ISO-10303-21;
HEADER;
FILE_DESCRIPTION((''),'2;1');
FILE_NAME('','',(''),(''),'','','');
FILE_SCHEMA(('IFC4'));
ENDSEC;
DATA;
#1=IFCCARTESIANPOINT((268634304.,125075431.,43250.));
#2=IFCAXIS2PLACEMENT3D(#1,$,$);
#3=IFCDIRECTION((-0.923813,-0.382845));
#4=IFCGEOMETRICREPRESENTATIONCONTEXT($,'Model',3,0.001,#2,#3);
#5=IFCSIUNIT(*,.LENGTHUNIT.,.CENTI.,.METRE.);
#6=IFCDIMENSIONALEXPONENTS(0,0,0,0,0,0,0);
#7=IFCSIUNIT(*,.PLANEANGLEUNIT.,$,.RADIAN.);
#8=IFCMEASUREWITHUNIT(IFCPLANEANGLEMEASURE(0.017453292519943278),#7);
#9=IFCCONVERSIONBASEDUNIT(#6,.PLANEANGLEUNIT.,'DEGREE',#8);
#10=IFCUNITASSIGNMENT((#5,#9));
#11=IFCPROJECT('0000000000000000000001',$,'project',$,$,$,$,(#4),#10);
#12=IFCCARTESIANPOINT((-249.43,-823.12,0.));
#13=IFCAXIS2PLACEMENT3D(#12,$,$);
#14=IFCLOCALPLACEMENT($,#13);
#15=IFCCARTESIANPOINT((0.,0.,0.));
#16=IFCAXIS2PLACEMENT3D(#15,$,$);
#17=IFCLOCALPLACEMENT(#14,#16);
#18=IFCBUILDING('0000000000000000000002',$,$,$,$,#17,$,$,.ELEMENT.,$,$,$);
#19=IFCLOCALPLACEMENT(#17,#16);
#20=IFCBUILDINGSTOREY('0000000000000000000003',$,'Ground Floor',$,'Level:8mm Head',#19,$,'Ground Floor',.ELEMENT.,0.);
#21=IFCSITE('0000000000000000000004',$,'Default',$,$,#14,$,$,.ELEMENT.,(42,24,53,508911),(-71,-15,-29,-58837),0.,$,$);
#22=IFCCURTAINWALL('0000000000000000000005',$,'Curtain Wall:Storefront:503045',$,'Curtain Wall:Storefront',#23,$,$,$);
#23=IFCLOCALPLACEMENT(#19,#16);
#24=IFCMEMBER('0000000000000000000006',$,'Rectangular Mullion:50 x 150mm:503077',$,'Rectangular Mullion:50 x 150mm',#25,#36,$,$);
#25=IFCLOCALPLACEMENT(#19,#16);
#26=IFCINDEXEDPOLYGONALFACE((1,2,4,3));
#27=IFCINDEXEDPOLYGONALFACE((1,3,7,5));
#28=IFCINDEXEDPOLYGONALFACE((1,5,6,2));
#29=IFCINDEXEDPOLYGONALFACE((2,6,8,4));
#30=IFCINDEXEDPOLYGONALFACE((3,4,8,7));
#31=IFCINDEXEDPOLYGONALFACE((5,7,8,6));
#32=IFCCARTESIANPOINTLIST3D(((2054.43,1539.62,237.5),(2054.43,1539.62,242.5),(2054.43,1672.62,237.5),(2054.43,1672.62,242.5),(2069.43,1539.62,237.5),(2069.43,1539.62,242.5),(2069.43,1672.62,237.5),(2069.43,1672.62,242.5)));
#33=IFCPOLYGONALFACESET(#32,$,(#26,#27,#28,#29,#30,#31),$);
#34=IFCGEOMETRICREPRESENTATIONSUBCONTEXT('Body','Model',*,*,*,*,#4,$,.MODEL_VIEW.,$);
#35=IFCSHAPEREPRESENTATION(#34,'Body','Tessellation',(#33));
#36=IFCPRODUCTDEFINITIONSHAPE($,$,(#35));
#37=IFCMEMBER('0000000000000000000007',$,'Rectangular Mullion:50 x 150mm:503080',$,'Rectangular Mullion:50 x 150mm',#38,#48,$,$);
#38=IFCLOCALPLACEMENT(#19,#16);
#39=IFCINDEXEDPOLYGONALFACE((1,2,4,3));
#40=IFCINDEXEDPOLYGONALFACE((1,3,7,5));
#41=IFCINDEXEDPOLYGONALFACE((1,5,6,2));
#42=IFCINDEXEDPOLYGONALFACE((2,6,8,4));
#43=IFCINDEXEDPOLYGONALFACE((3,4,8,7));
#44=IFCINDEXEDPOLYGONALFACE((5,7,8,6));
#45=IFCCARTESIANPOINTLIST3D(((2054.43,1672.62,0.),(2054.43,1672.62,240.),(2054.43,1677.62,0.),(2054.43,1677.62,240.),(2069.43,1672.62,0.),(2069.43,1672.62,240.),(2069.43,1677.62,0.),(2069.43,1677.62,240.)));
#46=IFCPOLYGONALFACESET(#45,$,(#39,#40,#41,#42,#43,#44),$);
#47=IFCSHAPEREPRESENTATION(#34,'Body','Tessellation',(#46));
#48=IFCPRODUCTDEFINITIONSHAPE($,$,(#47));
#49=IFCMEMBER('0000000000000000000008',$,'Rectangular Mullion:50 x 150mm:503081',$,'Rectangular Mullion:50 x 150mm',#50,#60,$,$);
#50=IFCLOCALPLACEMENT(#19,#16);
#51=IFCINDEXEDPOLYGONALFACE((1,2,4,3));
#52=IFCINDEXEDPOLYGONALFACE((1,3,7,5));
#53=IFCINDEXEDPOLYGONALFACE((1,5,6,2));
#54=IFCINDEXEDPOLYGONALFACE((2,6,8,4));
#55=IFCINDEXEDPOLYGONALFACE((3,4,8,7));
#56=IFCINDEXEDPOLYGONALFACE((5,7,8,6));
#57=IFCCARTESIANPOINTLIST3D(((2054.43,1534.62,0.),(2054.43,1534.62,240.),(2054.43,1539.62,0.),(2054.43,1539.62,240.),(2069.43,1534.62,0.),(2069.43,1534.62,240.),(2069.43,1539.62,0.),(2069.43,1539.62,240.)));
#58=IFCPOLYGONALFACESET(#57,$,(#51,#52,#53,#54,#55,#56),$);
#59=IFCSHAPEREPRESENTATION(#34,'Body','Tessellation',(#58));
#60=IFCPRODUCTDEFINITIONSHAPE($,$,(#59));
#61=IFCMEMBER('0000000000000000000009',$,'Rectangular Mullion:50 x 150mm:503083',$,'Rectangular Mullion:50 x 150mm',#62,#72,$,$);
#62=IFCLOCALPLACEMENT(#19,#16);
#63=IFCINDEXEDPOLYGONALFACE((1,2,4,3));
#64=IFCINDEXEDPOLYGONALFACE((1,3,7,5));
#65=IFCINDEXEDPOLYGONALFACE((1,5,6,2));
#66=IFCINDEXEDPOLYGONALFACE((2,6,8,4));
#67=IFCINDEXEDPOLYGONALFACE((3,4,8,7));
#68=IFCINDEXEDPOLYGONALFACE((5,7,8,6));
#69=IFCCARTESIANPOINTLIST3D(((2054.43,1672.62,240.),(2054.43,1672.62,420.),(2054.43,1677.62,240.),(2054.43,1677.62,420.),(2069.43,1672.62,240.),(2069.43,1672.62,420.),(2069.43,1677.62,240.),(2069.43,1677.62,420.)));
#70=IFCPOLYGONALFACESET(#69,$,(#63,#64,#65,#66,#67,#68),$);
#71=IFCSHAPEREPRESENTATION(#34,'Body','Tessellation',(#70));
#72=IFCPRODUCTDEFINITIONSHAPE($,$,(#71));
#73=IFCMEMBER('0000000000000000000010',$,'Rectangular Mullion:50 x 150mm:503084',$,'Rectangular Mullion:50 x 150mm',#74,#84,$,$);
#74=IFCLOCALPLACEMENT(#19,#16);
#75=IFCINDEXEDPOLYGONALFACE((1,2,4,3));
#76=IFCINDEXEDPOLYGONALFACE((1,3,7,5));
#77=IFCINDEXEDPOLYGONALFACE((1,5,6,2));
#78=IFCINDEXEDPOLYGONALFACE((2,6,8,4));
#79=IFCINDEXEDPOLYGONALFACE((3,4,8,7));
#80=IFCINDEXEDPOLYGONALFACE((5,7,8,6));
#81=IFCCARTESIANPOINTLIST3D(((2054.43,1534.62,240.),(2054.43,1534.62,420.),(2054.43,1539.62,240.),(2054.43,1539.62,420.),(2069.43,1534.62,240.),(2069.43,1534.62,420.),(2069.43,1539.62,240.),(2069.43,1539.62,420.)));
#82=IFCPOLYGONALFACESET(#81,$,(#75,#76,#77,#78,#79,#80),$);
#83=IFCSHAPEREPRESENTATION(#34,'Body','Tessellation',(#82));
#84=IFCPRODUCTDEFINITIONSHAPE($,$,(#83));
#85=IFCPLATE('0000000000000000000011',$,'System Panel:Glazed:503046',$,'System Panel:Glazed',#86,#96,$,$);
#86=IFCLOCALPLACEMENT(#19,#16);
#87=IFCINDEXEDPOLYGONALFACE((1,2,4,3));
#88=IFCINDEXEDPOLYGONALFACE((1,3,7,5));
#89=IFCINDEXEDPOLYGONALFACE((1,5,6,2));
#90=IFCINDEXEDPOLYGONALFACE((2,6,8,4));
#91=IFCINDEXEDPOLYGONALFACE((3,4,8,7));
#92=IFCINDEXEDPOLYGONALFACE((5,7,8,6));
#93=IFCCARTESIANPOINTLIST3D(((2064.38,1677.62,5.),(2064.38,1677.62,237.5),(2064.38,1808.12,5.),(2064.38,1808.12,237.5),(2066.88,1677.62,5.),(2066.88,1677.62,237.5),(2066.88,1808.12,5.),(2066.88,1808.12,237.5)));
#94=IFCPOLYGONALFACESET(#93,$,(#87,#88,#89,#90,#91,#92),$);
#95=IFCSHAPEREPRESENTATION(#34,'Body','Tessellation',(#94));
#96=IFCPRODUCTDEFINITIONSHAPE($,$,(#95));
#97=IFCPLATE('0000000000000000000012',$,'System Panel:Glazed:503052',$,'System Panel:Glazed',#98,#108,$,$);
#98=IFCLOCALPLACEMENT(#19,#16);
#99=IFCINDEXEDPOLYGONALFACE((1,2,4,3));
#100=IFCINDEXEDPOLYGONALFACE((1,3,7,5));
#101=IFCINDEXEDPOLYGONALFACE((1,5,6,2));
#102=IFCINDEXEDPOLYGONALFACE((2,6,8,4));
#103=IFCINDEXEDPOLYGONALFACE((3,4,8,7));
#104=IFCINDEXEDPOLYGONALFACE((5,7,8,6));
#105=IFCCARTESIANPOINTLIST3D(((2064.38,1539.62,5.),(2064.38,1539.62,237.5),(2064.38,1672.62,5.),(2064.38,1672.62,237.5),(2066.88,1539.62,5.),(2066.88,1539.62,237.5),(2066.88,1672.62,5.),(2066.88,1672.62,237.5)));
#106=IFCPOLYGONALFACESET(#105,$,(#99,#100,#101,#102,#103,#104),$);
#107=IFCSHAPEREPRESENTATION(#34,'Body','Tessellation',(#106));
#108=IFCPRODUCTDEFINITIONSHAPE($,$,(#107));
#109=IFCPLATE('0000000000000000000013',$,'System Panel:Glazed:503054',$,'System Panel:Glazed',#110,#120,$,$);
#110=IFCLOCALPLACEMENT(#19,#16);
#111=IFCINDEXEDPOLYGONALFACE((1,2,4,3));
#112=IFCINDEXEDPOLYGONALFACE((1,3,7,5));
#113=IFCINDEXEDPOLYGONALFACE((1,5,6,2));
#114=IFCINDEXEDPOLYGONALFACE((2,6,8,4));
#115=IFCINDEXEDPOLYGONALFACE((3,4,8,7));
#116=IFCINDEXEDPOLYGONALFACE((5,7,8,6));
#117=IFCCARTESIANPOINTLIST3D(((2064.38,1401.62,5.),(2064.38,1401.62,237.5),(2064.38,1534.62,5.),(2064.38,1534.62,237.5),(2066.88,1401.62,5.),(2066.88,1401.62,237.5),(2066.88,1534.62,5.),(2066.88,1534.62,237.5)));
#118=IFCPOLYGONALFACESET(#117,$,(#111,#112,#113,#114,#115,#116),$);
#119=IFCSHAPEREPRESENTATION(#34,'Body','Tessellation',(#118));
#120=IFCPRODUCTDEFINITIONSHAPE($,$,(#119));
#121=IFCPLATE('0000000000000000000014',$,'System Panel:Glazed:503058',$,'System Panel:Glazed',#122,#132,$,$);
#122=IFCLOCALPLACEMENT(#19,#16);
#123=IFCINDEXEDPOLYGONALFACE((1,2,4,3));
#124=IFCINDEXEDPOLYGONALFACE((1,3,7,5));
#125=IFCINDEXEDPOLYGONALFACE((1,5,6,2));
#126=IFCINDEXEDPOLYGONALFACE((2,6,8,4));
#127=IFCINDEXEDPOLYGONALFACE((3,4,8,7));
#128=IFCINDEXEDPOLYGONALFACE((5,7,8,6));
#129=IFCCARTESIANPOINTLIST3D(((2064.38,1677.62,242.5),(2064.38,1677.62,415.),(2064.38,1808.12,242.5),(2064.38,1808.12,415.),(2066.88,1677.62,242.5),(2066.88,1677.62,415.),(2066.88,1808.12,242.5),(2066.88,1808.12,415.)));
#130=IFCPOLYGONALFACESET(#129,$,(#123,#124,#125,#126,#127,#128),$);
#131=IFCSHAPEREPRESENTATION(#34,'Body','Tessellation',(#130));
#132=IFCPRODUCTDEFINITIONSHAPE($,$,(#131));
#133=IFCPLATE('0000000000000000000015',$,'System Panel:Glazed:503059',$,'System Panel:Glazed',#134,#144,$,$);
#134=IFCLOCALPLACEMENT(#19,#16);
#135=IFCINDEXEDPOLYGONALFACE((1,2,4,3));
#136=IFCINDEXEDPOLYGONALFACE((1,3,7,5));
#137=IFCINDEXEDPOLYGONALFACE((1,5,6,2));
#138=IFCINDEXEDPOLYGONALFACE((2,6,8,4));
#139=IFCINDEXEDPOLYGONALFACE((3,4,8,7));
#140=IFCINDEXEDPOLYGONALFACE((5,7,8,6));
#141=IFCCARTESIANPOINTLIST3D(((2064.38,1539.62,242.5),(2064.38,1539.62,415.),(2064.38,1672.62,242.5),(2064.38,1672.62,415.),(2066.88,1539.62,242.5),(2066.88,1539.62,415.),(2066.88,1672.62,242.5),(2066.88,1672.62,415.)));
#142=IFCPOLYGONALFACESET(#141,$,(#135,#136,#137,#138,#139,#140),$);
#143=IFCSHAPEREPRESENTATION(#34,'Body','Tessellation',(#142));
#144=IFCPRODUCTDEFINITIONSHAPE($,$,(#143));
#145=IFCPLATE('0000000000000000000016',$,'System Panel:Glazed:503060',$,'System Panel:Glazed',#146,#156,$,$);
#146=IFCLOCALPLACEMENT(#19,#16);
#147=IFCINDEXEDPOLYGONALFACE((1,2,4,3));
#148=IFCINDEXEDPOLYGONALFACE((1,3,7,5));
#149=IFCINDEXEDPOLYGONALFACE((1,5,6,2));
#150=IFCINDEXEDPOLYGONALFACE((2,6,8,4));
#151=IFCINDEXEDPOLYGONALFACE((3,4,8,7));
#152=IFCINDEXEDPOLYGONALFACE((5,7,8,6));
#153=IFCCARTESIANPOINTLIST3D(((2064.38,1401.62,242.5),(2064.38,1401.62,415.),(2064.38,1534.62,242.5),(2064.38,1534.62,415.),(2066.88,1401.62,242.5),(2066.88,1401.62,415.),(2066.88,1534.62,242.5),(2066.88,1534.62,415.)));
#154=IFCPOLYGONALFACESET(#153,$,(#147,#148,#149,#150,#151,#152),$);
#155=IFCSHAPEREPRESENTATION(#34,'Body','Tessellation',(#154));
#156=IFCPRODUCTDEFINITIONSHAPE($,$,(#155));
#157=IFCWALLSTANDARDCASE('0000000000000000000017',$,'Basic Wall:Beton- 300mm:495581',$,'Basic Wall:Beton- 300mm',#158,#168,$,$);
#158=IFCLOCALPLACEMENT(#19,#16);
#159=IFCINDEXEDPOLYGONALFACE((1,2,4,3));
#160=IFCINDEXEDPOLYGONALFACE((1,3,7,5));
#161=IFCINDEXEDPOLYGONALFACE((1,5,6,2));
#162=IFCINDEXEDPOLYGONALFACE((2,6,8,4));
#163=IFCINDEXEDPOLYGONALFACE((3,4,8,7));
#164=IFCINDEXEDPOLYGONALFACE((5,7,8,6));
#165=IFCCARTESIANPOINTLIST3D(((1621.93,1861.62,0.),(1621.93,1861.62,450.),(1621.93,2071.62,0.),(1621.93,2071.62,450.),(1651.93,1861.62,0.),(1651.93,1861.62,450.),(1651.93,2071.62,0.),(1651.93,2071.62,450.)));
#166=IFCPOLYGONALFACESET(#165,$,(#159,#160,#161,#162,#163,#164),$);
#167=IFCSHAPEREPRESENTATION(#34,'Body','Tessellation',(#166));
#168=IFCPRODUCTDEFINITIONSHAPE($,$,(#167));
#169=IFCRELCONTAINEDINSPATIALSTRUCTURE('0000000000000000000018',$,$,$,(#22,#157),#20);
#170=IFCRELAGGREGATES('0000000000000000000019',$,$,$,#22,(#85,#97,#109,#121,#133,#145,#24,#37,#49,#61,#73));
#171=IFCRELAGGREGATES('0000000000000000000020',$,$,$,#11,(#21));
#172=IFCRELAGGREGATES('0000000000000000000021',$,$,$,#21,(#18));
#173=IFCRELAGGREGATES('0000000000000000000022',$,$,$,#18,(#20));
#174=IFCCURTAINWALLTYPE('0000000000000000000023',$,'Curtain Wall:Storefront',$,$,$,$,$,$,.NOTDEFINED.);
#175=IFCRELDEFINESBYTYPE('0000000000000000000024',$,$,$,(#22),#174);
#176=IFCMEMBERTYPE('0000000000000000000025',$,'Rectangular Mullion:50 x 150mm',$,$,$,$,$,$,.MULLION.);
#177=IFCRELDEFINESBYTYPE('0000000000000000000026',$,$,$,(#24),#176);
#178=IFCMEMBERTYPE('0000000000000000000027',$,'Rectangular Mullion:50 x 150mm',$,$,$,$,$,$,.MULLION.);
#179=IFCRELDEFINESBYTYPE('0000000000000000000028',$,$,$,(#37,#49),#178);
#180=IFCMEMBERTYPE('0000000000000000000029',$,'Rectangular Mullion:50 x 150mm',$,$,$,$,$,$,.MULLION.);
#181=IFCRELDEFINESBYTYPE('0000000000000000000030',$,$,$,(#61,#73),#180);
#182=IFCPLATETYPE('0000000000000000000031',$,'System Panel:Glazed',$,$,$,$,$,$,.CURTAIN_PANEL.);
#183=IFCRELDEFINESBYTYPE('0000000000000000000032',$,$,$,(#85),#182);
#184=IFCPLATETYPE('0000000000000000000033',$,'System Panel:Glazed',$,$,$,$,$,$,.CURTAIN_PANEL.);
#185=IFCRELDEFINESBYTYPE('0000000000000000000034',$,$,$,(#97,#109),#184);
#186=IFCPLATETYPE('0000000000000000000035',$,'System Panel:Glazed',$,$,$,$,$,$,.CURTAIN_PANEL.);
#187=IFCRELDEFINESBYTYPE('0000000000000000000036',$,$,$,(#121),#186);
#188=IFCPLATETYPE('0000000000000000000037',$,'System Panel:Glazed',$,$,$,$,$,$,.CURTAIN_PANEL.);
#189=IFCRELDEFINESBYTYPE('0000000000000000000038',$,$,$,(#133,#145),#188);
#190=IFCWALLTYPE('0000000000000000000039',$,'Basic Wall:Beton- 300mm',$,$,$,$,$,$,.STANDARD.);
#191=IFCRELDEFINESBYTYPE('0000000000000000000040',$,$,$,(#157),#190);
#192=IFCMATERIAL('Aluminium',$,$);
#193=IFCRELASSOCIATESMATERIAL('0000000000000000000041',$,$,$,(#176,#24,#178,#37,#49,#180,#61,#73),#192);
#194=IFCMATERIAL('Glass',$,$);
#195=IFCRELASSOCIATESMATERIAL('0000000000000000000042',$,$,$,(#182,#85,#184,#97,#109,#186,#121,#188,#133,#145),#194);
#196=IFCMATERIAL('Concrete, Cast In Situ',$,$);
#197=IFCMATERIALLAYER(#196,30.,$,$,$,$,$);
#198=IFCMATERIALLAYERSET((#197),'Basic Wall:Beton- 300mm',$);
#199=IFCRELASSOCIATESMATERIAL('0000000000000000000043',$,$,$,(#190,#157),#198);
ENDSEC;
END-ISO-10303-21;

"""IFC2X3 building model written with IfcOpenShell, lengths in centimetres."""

from ifc_helpers import new_model, entity, si_unit, converted_unit, direction, frame, frame_2d, origin, origin_2d_with_axis, place, context, subcontext, project, spatial, rectangle, extrude, source, transform, mapped, material, layer, layer_set, layer_usage, type_object, type_shapes, element, aggregate, save


model = new_model("IFC2X3")

# Units and contexts
model_context = context("Model", 3, precision=0.001, world=frame((268634304.0, 125075431.0, 43250.0)), true_north=direction((-0.923813, -0.382845)))
body_context = subcontext(model_context, "Body", "Model", "MODEL_VIEW")
ifc_project = project(units=[si_unit("LENGTHUNIT", "METRE", prefix="CENTI"), converted_unit("PLANEANGLEUNIT", "DEGREE", entity("IfcPlaneAngleMeasure", 0.017453292519943278), si_unit("PLANEANGLEUNIT", "RADIAN"), dimensions=[0, 0, 0, 0, 0, 0, 0])], contexts=[model_context])

# Site, building, storey
site_placement = place(None, frame((-249.43, -823.12, 0.0)))
site = spatial("IfcSite", under=ifc_project, at=site_placement, Name="Default", CompositionType="ELEMENT", RefLatitude=(42, 24, 53, 508911), RefLongitude=(-71, -15, -29, -58837), RefElevation=0.0)
building_placement = place(site_placement, origin())
building = spatial("IfcBuilding", under=site, at=building_placement, CompositionType="ELEMENT")
storey_placement = place(building_placement, origin())
storey = spatial("IfcBuildingStorey", under=building, at=storey_placement, Name="Ground Floor", ObjectType="Level:8mm Head", LongName="Ground Floor", CompositionType="ELEMENT", Elevation=0.0)

# Curtain wall, members, plates
curtain_wall_type = type_object("IfcCurtainWallType", Name="Curtain Wall:Storefront", PredefinedType="NOTDEFINED")
curtain_wall_placement = place(storey_placement, origin())
curtain_wall = element("IfcCurtainWall", 1, at=curtain_wall_placement, inside=storey, type_object=curtain_wall_type, Name="Curtain Wall:Storefront:503045", ObjectType="Curtain Wall:Storefront")
ifc_material_1 = material(Name="Aluminium")
member_type_1 = type_object("IfcMemberType", Name="Rectangular Mullion:50 x 150mm", PredefinedType="MULLION", material=ifc_material_1)
shared_shape_1 = source(origin(), body_context, "Body", "SweptSolid", [
    extrude(rectangle(XDim=5.0, YDim=15.0, at=origin_2d_with_axis()), frame((0.0, 0.0, -133.0), z_axis=(0.0, 0.0, 1.0), x_axis=(-1.0, 0.0, 0.0)), (0.0, 0.0, 1.0), 133.0),
])
type_shapes(member_type_1, [shared_shape_1])
member_1_placement = place(curtain_wall_placement, frame((2061.93, 1539.62, 240.0), z_axis=(0.0, -1.0, 0.0), x_axis=(0.0, 0.0, 1.0)))
member_1 = element("IfcMember", 2, at=member_1_placement, type_object=member_type_1, material=ifc_material_1, Name="Rectangular Mullion:50 x 150mm:503077", ObjectType="Rectangular Mullion:50 x 150mm", context=body_context, shape_type="MappedRepresentation", body=[
    mapped(shared_shape_1, transform((0.0, 0.0, 0.0), scale=1.0)),
])
member_type_2 = type_object("IfcMemberType", Name="Rectangular Mullion:50 x 150mm", PredefinedType="MULLION", material=ifc_material_1)
shared_shape_2 = source(origin(), body_context, "Body", "SweptSolid", [
    extrude(rectangle(XDim=5.0, YDim=15.0, at=origin_2d_with_axis()), frame((0.0, 0.0, -240.0), z_axis=(0.0, 0.0, 1.0), x_axis=(-1.0, 0.0, 0.0)), (0.0, 0.0, 1.0), 240.0),
])
type_shapes(member_type_2, [shared_shape_2])
member_2_placement = place(curtain_wall_placement, frame((2061.93, 1675.12, 0.0), z_axis=(0.0, 0.0, -1.0), x_axis=(0.0, -1.0, 0.0)))
member_2 = element("IfcMember", 3, at=member_2_placement, type_object=member_type_2, material=ifc_material_1, Name="Rectangular Mullion:50 x 150mm:503080", ObjectType="Rectangular Mullion:50 x 150mm", context=body_context, shape_type="MappedRepresentation", body=[
    mapped(shared_shape_2, transform((0.0, 0.0, 0.0), scale=1.0)),
])
member_3_placement = place(curtain_wall_placement, frame((2061.93, 1537.12, 0.0), z_axis=(0.0, 0.0, -1.0), x_axis=(0.0, -1.0, 0.0)))
member_3 = element("IfcMember", 4, at=member_3_placement, type_object=member_type_2, material=ifc_material_1, Name="Rectangular Mullion:50 x 150mm:503081", ObjectType="Rectangular Mullion:50 x 150mm", context=body_context, shape_type="MappedRepresentation", body=[
    mapped(shared_shape_2, transform((0.0, 0.0, 0.0), scale=1.0)),
])
member_type_3 = type_object("IfcMemberType", Name="Rectangular Mullion:50 x 150mm", PredefinedType="MULLION", material=ifc_material_1)
shared_shape_3 = source(origin(), body_context, "Body", "SweptSolid", [
    extrude(rectangle(XDim=5.0, YDim=15.0, at=origin_2d_with_axis()), frame((0.0, 0.0, -180.0), z_axis=(0.0, 0.0, 1.0), x_axis=(-1.0, 0.0, 0.0)), (0.0, 0.0, 1.0), 180.0),
])
type_shapes(member_type_3, [shared_shape_3])
member_4_placement = place(curtain_wall_placement, frame((2061.93, 1675.12, 240.0), z_axis=(0.0, 0.0, -1.0), x_axis=(0.0, -1.0, 0.0)))
member_4 = element("IfcMember", 5, at=member_4_placement, type_object=member_type_3, material=ifc_material_1, Name="Rectangular Mullion:50 x 150mm:503083", ObjectType="Rectangular Mullion:50 x 150mm", context=body_context, shape_type="MappedRepresentation", body=[
    mapped(shared_shape_3, transform((0.0, 0.0, 0.0), scale=1.0)),
])
member_5_placement = place(curtain_wall_placement, frame((2061.93, 1537.12, 240.0), z_axis=(0.0, 0.0, -1.0), x_axis=(0.0, -1.0, 0.0)))
member_5 = element("IfcMember", 6, at=member_5_placement, type_object=member_type_3, material=ifc_material_1, Name="Rectangular Mullion:50 x 150mm:503084", ObjectType="Rectangular Mullion:50 x 150mm", context=body_context, shape_type="MappedRepresentation", body=[
    mapped(shared_shape_3, transform((0.0, 0.0, 0.0), scale=1.0)),
])
ifc_material_2 = material(Name="Glass")
plate_type_1 = type_object("IfcPlateType", Name="System Panel:Glazed", PredefinedType="CURTAIN_PANEL", material=ifc_material_2)
shared_shape_4 = source(origin(), body_context, "Body", "SweptSolid", [
    extrude(rectangle(XDim=2.5, YDim=130.5, at=origin_2d_with_axis()), frame((65.25, 1.25, 0.0), z_axis=(0.0, 0.0, 1.0), x_axis=(0.0, 1.0, 0.0)), (0.0, 0.0, 1.0), 232.5),
])
type_shapes(plate_type_1, [shared_shape_4])
plate_1_placement = place(curtain_wall_placement, frame((2064.38, 1808.12, 5.0), z_axis=(0.0, 0.0, 1.0), x_axis=(0.0, -1.0, 0.0)))
plate_1 = element("IfcPlate", 7, at=plate_1_placement, type_object=plate_type_1, material=ifc_material_2, Name="System Panel:Glazed:503046", ObjectType="System Panel:Glazed", context=body_context, shape_type="MappedRepresentation", body=[
    mapped(shared_shape_4, transform((0.0, 0.0, 0.0), scale=1.0)),
])
plate_type_2 = type_object("IfcPlateType", Name="System Panel:Glazed", PredefinedType="CURTAIN_PANEL", material=ifc_material_2)
shared_shape_5 = source(origin(), body_context, "Body", "SweptSolid", [
    extrude(rectangle(XDim=2.5, YDim=133.0, at=origin_2d_with_axis()), frame((66.5, 1.25, 0.0), z_axis=(0.0, 0.0, 1.0), x_axis=(0.0, 1.0, 0.0)), (0.0, 0.0, 1.0), 232.5),
])
type_shapes(plate_type_2, [shared_shape_5])
plate_2_placement = place(curtain_wall_placement, frame((2064.38, 1672.62, 5.0), z_axis=(0.0, 0.0, 1.0), x_axis=(0.0, -1.0, 0.0)))
plate_2 = element("IfcPlate", 8, at=plate_2_placement, type_object=plate_type_2, material=ifc_material_2, Name="System Panel:Glazed:503052", ObjectType="System Panel:Glazed", context=body_context, shape_type="MappedRepresentation", body=[
    mapped(shared_shape_5, transform((0.0, 0.0, 0.0), scale=1.0)),
])
plate_3_placement = place(curtain_wall_placement, frame((2064.38, 1534.62, 5.0), z_axis=(0.0, 0.0, 1.0), x_axis=(0.0, -1.0, 0.0)))
plate_3 = element("IfcPlate", 9, at=plate_3_placement, type_object=plate_type_2, material=ifc_material_2, Name="System Panel:Glazed:503054", ObjectType="System Panel:Glazed", context=body_context, shape_type="MappedRepresentation", body=[
    mapped(shared_shape_5, transform((0.0, 0.0, 0.0), scale=1.0)),
])
plate_type_3 = type_object("IfcPlateType", Name="System Panel:Glazed", PredefinedType="CURTAIN_PANEL", material=ifc_material_2)
shared_shape_6 = source(origin(), body_context, "Body", "SweptSolid", [
    extrude(rectangle(XDim=2.5, YDim=130.5, at=origin_2d_with_axis()), frame((65.25, 1.25, 0.0), z_axis=(0.0, 0.0, 1.0), x_axis=(0.0, 1.0, 0.0)), (0.0, 0.0, 1.0), 172.5),
])
type_shapes(plate_type_3, [shared_shape_6])
plate_4_placement = place(curtain_wall_placement, frame((2064.38, 1808.12, 242.5), z_axis=(0.0, 0.0, 1.0), x_axis=(0.0, -1.0, 0.0)))
plate_4 = element("IfcPlate", 10, at=plate_4_placement, type_object=plate_type_3, material=ifc_material_2, Name="System Panel:Glazed:503058", ObjectType="System Panel:Glazed", context=body_context, shape_type="MappedRepresentation", body=[
    mapped(shared_shape_6, transform((0.0, 0.0, 0.0), scale=1.0)),
])
plate_type_4 = type_object("IfcPlateType", Name="System Panel:Glazed", PredefinedType="CURTAIN_PANEL", material=ifc_material_2)
shared_shape_7 = source(origin(), body_context, "Body", "SweptSolid", [
    extrude(rectangle(XDim=2.5, YDim=133.0, at=origin_2d_with_axis()), frame((66.5, 1.25, 0.0), z_axis=(0.0, 0.0, 1.0), x_axis=(0.0, 1.0, 0.0)), (0.0, 0.0, 1.0), 172.5),
])
type_shapes(plate_type_4, [shared_shape_7])
plate_5_placement = place(curtain_wall_placement, frame((2064.38, 1672.62, 242.5), z_axis=(0.0, 0.0, 1.0), x_axis=(0.0, -1.0, 0.0)))
plate_5 = element("IfcPlate", 11, at=plate_5_placement, type_object=plate_type_4, material=ifc_material_2, Name="System Panel:Glazed:503059", ObjectType="System Panel:Glazed", context=body_context, shape_type="MappedRepresentation", body=[
    mapped(shared_shape_7, transform((0.0, 0.0, 0.0), scale=1.0)),
])
plate_6_placement = place(curtain_wall_placement, frame((2064.38, 1534.62, 242.5), z_axis=(0.0, 0.0, 1.0), x_axis=(0.0, -1.0, 0.0)))
plate_6 = element("IfcPlate", 12, at=plate_6_placement, type_object=plate_type_4, material=ifc_material_2, Name="System Panel:Glazed:503060", ObjectType="System Panel:Glazed", context=body_context, shape_type="MappedRepresentation", body=[
    mapped(shared_shape_7, transform((0.0, 0.0, 0.0), scale=1.0)),
])
aggregate(curtain_wall, [plate_1, plate_2, plate_3, plate_4, plate_5, plate_6, member_1, member_2, member_3, member_4, member_5])

# Wall
ifc_material_3 = material(Name="Concrete, Cast In Situ")
ifc_layer_1 = layer(ifc_material_3, 30.0)
ifc_layer_set_1 = layer_set([ifc_layer_1], Name="Basic Wall:Beton- 300mm")
ifc_layer_usage_1 = layer_usage(ifc_layer_set_1, "AXIS2", "POSITIVE", -15.0)
wall_type_1 = type_object("IfcWallType", Name="Basic Wall:Beton- 300mm", PredefinedType="STANDARD", material=ifc_layer_set_1)
wall_1_placement = place(storey_placement, frame((1636.93, 1861.62, 0.0), z_axis=(0.0, 0.0, 1.0), x_axis=(0.0, 1.0, 0.0)))
element("IfcWallStandardCase", 13, at=wall_1_placement, inside=storey, type_object=wall_type_1, material=ifc_layer_usage_1, Name="Basic Wall:Beton- 300mm:495581", ObjectType="Basic Wall:Beton- 300mm", context=body_context, shape_type="SweptSolid", body=[
    extrude(rectangle(XDim=210.0, YDim=30.0, at=frame_2d((105.0, 0.0), x_axis=(-1.0, 0.0))), origin(), (0.0, 0.0, 1.0), 450.0),
])

save(model, "model.ifc")
